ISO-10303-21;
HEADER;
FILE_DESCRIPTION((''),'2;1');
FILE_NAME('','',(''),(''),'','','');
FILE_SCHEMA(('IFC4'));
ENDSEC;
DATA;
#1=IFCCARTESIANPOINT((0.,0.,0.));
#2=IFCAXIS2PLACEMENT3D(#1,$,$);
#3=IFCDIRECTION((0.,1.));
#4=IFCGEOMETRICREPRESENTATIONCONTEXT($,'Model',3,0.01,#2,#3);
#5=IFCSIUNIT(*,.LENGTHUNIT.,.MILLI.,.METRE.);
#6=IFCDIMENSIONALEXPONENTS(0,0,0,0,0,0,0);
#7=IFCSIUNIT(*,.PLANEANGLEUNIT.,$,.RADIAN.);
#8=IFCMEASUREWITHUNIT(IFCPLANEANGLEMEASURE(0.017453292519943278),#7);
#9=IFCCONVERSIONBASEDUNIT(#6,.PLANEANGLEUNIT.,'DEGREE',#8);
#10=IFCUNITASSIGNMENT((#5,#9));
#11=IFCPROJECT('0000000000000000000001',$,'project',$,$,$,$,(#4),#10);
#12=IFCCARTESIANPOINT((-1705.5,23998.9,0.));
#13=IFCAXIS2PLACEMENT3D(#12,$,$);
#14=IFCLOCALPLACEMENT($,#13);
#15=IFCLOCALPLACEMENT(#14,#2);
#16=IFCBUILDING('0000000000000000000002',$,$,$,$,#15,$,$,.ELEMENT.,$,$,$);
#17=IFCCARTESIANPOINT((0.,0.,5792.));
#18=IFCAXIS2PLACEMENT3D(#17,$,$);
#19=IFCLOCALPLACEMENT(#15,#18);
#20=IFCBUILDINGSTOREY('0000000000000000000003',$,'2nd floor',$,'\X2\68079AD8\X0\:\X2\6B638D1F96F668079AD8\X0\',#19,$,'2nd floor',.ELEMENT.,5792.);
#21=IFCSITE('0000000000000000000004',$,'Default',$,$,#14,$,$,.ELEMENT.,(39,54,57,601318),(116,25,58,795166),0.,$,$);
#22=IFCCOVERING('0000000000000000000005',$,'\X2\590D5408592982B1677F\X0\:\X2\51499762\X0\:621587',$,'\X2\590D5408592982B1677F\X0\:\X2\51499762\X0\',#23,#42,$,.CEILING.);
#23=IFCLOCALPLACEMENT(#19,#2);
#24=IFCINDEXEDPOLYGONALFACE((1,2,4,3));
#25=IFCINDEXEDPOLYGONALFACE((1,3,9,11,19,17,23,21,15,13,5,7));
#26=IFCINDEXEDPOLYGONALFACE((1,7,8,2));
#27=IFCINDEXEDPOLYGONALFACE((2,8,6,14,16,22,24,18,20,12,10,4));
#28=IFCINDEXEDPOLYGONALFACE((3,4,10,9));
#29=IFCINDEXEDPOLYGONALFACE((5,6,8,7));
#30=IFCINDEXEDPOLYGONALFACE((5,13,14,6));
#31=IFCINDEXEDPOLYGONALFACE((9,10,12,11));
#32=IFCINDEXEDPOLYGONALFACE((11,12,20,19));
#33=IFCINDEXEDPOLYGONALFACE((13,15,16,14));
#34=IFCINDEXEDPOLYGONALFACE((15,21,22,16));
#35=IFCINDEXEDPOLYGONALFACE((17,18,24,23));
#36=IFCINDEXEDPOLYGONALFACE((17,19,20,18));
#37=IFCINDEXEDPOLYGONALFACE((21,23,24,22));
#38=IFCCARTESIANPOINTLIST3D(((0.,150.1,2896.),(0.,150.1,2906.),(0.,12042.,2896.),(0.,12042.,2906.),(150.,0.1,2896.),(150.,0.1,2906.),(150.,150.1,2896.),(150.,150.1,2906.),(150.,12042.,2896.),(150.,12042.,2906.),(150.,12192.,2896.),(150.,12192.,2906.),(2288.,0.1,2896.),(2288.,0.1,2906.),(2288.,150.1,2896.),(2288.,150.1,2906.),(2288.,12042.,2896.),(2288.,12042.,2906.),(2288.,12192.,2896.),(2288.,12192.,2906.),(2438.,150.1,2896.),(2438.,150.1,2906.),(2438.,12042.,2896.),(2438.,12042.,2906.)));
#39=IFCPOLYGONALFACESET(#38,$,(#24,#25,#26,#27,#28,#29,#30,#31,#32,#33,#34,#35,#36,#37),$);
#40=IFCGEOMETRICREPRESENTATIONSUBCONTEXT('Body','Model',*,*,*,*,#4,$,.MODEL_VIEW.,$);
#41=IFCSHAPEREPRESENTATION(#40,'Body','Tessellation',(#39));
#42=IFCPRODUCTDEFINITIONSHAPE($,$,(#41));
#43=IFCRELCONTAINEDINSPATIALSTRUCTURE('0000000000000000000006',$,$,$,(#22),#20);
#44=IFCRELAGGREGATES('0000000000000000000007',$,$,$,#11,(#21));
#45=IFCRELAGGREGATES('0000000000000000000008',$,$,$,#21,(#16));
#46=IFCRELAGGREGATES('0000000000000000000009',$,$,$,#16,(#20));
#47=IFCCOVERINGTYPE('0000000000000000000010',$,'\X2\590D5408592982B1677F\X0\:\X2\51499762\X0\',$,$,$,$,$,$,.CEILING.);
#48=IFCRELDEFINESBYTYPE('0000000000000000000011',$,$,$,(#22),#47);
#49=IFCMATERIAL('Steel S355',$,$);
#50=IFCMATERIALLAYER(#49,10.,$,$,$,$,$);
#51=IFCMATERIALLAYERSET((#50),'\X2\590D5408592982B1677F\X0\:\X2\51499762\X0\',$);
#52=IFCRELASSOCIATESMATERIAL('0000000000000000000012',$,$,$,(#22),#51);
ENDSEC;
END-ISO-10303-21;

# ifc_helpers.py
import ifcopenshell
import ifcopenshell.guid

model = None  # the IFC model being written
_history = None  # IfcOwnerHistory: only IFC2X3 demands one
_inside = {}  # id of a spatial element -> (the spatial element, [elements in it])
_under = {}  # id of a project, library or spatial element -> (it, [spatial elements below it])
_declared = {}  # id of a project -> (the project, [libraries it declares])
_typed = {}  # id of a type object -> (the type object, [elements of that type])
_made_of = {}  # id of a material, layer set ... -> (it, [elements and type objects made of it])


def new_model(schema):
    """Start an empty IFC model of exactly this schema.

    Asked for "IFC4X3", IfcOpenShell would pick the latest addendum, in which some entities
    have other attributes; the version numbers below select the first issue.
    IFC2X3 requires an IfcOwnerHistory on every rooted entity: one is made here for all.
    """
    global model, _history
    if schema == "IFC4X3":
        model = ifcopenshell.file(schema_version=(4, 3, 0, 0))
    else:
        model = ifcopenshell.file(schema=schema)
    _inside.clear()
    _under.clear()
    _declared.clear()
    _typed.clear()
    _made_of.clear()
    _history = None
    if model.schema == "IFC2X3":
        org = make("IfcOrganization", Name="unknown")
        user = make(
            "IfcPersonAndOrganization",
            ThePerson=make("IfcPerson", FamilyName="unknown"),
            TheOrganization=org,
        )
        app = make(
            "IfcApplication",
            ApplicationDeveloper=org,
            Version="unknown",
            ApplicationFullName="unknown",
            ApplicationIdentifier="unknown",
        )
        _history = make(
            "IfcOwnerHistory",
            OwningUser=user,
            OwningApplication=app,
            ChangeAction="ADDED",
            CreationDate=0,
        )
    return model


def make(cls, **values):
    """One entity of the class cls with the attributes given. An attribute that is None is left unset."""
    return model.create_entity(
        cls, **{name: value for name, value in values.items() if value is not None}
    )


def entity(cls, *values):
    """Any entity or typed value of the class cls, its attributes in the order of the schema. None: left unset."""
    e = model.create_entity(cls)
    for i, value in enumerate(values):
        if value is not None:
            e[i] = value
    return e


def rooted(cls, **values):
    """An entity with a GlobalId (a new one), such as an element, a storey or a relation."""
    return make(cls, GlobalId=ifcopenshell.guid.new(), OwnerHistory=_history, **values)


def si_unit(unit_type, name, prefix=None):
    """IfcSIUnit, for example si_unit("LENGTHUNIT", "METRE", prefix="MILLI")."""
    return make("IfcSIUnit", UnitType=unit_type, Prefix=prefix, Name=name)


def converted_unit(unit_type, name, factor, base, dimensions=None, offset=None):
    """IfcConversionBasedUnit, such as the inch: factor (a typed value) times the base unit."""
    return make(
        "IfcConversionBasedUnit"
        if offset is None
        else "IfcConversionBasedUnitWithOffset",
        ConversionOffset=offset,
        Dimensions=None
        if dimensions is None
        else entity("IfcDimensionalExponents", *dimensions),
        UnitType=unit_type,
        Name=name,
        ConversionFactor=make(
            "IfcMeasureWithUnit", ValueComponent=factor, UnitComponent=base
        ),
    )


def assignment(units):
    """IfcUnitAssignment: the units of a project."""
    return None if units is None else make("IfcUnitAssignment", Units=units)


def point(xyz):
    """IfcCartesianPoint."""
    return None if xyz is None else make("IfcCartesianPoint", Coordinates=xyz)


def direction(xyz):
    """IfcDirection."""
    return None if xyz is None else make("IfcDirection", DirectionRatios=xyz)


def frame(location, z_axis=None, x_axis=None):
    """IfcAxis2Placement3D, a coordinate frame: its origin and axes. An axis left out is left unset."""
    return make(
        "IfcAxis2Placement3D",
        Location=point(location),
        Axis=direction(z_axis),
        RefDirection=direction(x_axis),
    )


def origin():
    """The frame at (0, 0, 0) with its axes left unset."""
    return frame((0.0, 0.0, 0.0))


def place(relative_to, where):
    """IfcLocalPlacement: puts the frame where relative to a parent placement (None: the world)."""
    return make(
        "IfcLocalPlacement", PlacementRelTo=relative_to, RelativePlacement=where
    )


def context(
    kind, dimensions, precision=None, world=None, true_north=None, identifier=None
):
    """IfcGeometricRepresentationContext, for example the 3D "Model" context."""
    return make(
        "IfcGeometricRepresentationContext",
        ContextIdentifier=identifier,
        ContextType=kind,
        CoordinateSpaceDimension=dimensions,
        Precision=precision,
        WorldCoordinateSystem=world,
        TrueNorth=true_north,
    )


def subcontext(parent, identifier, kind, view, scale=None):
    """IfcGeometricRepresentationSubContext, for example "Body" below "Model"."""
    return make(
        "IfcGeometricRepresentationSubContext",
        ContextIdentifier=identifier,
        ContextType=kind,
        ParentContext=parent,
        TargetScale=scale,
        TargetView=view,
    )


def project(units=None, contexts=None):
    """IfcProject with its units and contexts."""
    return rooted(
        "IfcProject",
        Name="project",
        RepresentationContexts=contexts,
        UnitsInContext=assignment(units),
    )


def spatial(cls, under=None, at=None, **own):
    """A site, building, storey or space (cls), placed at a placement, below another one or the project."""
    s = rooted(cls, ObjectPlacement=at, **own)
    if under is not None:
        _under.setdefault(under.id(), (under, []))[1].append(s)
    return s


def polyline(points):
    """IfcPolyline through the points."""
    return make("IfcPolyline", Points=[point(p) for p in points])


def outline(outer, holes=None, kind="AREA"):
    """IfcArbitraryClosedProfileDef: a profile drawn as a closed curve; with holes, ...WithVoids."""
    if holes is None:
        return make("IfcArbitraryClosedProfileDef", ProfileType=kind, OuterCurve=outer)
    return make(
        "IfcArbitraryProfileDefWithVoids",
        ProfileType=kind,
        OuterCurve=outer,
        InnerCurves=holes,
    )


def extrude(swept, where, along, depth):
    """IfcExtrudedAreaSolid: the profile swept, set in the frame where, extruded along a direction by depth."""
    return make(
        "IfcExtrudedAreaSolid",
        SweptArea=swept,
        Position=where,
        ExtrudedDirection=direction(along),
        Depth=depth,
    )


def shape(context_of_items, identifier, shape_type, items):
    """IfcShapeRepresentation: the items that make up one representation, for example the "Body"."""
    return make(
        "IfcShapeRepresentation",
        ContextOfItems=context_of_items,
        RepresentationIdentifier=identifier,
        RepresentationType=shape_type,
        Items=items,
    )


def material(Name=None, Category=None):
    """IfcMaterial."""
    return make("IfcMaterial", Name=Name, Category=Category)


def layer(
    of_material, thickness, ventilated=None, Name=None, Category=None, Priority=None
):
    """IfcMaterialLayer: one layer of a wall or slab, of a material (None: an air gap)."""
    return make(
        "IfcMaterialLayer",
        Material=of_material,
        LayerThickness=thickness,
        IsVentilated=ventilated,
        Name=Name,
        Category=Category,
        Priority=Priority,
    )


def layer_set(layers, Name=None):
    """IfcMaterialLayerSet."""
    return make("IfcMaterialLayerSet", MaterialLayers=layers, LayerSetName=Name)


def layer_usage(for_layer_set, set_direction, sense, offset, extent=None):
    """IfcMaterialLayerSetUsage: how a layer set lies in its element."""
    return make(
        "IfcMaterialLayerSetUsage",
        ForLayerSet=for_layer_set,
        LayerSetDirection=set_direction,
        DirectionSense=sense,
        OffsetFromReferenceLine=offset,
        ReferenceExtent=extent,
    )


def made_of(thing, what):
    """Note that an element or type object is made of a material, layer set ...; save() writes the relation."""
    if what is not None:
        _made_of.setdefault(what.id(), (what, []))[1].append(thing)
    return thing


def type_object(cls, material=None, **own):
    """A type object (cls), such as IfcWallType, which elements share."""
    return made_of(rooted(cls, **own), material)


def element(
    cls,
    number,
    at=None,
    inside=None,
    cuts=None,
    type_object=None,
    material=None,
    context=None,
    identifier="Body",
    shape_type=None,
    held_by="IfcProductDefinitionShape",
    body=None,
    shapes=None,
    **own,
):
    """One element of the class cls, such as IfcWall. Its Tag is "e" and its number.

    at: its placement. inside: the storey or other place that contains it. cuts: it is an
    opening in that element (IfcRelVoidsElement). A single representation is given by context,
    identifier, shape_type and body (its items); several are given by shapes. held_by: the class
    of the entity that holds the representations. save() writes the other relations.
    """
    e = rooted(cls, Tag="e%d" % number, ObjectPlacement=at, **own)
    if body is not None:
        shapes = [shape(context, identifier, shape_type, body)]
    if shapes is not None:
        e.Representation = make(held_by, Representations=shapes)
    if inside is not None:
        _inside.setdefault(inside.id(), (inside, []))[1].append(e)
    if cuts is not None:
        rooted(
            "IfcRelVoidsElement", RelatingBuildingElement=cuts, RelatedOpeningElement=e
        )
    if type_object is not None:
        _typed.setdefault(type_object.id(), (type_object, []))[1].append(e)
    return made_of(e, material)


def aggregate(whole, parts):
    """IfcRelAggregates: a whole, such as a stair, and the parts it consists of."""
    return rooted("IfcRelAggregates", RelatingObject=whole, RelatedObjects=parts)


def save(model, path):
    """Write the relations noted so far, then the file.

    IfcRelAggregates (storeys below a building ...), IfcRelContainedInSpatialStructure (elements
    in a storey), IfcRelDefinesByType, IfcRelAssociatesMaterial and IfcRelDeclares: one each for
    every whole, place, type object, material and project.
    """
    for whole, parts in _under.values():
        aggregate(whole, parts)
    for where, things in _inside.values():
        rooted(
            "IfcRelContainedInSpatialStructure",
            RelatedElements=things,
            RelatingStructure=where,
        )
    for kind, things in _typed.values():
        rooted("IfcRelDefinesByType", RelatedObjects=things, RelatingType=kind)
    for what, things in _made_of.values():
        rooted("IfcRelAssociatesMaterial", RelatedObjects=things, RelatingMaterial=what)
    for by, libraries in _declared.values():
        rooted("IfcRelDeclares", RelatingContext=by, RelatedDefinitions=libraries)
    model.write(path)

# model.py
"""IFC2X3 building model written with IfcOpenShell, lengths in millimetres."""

from ifc_helpers import new_model, entity, si_unit, converted_unit, direction, frame, origin, place, context, subcontext, project, spatial, polyline, outline, extrude, material, layer, layer_set, layer_usage, type_object, element, save


model = new_model("IFC2X3")

# Units and contexts
model_context = context("Model", 3, precision=0.01, world=origin(), true_north=direction((0.0, 1.0)))
body_context = subcontext(model_context, "Body", "Model", "MODEL_VIEW")
ifc_project = project(units=[si_unit("LENGTHUNIT", "METRE", prefix="MILLI"), converted_unit("PLANEANGLEUNIT", "DEGREE", entity("IfcPlaneAngleMeasure", 0.017453292519943278), si_unit("PLANEANGLEUNIT", "RADIAN"), dimensions=[0, 0, 0, 0, 0, 0, 0])], contexts=[model_context])

# Site, building, storey
site_placement = place(None, frame((-1705.5, 23998.9, 0.0)))
site = spatial("IfcSite", under=ifc_project, at=site_placement, Name="Default", CompositionType="ELEMENT", RefLatitude=(39, 54, 57, 601318), RefLongitude=(116, 25, 58, 795166), RefElevation=0.0)
building_placement = place(site_placement, origin())
building = spatial("IfcBuilding", under=site, at=building_placement, CompositionType="ELEMENT")
storey_placement = place(building_placement, frame((0.0, 0.0, 5792.0)))
storey = spatial("IfcBuildingStorey", under=building, at=storey_placement, Name="2nd floor", ObjectType="标高:正负零标高", LongName="2nd floor", CompositionType="ELEMENT", Elevation=5792.0)

# Shared definitions
ifc_material_1 = material(Name="Steel S355")

# Covering
ifc_layer_1 = layer(ifc_material_1, 10.0)
ifc_layer_set_1 = layer_set([ifc_layer_1], Name="复合天花板:光面")
ifc_layer_usage_1 = layer_usage(ifc_layer_set_1, "AXIS3", "NEGATIVE", 10.0)
covering_type = type_object("IfcCoveringType", Name="复合天花板:光面", PredefinedType="CEILING")
covering_placement = place(storey_placement, origin())
element("IfcCovering", 1, at=covering_placement, inside=storey, type_object=covering_type, material=ifc_layer_usage_1, Name="复合天花板:光面:621587", ObjectType="复合天花板:光面", PredefinedType="CEILING", context=body_context, shape_type="SweptSolid", body=[
    extrude(outline(polyline([(5946.0, -1069.0), (6096.0, -1069.0), (6096.0, 1069.0), (5945.9, 1069.0), (5945.9, 1219.0), (-5946.0, 1219.0), (-5946.0, 1069.0), (-6096.0, 1069.0), (-6096.0, -1069.0), (-5946.0, -1069.0), (-5946.0, -1219.0), (5946.0, -1219.0), (5946.0, -1069.0)])), frame((1219.0, 6096.0, 2896.0), z_axis=(0.0, 0.0, 1.0), x_axis=(0.0, 1.0, 0.0)), (0.0, 0.0, 1.0), 10.0),
])

save(model, "model.ifc")
